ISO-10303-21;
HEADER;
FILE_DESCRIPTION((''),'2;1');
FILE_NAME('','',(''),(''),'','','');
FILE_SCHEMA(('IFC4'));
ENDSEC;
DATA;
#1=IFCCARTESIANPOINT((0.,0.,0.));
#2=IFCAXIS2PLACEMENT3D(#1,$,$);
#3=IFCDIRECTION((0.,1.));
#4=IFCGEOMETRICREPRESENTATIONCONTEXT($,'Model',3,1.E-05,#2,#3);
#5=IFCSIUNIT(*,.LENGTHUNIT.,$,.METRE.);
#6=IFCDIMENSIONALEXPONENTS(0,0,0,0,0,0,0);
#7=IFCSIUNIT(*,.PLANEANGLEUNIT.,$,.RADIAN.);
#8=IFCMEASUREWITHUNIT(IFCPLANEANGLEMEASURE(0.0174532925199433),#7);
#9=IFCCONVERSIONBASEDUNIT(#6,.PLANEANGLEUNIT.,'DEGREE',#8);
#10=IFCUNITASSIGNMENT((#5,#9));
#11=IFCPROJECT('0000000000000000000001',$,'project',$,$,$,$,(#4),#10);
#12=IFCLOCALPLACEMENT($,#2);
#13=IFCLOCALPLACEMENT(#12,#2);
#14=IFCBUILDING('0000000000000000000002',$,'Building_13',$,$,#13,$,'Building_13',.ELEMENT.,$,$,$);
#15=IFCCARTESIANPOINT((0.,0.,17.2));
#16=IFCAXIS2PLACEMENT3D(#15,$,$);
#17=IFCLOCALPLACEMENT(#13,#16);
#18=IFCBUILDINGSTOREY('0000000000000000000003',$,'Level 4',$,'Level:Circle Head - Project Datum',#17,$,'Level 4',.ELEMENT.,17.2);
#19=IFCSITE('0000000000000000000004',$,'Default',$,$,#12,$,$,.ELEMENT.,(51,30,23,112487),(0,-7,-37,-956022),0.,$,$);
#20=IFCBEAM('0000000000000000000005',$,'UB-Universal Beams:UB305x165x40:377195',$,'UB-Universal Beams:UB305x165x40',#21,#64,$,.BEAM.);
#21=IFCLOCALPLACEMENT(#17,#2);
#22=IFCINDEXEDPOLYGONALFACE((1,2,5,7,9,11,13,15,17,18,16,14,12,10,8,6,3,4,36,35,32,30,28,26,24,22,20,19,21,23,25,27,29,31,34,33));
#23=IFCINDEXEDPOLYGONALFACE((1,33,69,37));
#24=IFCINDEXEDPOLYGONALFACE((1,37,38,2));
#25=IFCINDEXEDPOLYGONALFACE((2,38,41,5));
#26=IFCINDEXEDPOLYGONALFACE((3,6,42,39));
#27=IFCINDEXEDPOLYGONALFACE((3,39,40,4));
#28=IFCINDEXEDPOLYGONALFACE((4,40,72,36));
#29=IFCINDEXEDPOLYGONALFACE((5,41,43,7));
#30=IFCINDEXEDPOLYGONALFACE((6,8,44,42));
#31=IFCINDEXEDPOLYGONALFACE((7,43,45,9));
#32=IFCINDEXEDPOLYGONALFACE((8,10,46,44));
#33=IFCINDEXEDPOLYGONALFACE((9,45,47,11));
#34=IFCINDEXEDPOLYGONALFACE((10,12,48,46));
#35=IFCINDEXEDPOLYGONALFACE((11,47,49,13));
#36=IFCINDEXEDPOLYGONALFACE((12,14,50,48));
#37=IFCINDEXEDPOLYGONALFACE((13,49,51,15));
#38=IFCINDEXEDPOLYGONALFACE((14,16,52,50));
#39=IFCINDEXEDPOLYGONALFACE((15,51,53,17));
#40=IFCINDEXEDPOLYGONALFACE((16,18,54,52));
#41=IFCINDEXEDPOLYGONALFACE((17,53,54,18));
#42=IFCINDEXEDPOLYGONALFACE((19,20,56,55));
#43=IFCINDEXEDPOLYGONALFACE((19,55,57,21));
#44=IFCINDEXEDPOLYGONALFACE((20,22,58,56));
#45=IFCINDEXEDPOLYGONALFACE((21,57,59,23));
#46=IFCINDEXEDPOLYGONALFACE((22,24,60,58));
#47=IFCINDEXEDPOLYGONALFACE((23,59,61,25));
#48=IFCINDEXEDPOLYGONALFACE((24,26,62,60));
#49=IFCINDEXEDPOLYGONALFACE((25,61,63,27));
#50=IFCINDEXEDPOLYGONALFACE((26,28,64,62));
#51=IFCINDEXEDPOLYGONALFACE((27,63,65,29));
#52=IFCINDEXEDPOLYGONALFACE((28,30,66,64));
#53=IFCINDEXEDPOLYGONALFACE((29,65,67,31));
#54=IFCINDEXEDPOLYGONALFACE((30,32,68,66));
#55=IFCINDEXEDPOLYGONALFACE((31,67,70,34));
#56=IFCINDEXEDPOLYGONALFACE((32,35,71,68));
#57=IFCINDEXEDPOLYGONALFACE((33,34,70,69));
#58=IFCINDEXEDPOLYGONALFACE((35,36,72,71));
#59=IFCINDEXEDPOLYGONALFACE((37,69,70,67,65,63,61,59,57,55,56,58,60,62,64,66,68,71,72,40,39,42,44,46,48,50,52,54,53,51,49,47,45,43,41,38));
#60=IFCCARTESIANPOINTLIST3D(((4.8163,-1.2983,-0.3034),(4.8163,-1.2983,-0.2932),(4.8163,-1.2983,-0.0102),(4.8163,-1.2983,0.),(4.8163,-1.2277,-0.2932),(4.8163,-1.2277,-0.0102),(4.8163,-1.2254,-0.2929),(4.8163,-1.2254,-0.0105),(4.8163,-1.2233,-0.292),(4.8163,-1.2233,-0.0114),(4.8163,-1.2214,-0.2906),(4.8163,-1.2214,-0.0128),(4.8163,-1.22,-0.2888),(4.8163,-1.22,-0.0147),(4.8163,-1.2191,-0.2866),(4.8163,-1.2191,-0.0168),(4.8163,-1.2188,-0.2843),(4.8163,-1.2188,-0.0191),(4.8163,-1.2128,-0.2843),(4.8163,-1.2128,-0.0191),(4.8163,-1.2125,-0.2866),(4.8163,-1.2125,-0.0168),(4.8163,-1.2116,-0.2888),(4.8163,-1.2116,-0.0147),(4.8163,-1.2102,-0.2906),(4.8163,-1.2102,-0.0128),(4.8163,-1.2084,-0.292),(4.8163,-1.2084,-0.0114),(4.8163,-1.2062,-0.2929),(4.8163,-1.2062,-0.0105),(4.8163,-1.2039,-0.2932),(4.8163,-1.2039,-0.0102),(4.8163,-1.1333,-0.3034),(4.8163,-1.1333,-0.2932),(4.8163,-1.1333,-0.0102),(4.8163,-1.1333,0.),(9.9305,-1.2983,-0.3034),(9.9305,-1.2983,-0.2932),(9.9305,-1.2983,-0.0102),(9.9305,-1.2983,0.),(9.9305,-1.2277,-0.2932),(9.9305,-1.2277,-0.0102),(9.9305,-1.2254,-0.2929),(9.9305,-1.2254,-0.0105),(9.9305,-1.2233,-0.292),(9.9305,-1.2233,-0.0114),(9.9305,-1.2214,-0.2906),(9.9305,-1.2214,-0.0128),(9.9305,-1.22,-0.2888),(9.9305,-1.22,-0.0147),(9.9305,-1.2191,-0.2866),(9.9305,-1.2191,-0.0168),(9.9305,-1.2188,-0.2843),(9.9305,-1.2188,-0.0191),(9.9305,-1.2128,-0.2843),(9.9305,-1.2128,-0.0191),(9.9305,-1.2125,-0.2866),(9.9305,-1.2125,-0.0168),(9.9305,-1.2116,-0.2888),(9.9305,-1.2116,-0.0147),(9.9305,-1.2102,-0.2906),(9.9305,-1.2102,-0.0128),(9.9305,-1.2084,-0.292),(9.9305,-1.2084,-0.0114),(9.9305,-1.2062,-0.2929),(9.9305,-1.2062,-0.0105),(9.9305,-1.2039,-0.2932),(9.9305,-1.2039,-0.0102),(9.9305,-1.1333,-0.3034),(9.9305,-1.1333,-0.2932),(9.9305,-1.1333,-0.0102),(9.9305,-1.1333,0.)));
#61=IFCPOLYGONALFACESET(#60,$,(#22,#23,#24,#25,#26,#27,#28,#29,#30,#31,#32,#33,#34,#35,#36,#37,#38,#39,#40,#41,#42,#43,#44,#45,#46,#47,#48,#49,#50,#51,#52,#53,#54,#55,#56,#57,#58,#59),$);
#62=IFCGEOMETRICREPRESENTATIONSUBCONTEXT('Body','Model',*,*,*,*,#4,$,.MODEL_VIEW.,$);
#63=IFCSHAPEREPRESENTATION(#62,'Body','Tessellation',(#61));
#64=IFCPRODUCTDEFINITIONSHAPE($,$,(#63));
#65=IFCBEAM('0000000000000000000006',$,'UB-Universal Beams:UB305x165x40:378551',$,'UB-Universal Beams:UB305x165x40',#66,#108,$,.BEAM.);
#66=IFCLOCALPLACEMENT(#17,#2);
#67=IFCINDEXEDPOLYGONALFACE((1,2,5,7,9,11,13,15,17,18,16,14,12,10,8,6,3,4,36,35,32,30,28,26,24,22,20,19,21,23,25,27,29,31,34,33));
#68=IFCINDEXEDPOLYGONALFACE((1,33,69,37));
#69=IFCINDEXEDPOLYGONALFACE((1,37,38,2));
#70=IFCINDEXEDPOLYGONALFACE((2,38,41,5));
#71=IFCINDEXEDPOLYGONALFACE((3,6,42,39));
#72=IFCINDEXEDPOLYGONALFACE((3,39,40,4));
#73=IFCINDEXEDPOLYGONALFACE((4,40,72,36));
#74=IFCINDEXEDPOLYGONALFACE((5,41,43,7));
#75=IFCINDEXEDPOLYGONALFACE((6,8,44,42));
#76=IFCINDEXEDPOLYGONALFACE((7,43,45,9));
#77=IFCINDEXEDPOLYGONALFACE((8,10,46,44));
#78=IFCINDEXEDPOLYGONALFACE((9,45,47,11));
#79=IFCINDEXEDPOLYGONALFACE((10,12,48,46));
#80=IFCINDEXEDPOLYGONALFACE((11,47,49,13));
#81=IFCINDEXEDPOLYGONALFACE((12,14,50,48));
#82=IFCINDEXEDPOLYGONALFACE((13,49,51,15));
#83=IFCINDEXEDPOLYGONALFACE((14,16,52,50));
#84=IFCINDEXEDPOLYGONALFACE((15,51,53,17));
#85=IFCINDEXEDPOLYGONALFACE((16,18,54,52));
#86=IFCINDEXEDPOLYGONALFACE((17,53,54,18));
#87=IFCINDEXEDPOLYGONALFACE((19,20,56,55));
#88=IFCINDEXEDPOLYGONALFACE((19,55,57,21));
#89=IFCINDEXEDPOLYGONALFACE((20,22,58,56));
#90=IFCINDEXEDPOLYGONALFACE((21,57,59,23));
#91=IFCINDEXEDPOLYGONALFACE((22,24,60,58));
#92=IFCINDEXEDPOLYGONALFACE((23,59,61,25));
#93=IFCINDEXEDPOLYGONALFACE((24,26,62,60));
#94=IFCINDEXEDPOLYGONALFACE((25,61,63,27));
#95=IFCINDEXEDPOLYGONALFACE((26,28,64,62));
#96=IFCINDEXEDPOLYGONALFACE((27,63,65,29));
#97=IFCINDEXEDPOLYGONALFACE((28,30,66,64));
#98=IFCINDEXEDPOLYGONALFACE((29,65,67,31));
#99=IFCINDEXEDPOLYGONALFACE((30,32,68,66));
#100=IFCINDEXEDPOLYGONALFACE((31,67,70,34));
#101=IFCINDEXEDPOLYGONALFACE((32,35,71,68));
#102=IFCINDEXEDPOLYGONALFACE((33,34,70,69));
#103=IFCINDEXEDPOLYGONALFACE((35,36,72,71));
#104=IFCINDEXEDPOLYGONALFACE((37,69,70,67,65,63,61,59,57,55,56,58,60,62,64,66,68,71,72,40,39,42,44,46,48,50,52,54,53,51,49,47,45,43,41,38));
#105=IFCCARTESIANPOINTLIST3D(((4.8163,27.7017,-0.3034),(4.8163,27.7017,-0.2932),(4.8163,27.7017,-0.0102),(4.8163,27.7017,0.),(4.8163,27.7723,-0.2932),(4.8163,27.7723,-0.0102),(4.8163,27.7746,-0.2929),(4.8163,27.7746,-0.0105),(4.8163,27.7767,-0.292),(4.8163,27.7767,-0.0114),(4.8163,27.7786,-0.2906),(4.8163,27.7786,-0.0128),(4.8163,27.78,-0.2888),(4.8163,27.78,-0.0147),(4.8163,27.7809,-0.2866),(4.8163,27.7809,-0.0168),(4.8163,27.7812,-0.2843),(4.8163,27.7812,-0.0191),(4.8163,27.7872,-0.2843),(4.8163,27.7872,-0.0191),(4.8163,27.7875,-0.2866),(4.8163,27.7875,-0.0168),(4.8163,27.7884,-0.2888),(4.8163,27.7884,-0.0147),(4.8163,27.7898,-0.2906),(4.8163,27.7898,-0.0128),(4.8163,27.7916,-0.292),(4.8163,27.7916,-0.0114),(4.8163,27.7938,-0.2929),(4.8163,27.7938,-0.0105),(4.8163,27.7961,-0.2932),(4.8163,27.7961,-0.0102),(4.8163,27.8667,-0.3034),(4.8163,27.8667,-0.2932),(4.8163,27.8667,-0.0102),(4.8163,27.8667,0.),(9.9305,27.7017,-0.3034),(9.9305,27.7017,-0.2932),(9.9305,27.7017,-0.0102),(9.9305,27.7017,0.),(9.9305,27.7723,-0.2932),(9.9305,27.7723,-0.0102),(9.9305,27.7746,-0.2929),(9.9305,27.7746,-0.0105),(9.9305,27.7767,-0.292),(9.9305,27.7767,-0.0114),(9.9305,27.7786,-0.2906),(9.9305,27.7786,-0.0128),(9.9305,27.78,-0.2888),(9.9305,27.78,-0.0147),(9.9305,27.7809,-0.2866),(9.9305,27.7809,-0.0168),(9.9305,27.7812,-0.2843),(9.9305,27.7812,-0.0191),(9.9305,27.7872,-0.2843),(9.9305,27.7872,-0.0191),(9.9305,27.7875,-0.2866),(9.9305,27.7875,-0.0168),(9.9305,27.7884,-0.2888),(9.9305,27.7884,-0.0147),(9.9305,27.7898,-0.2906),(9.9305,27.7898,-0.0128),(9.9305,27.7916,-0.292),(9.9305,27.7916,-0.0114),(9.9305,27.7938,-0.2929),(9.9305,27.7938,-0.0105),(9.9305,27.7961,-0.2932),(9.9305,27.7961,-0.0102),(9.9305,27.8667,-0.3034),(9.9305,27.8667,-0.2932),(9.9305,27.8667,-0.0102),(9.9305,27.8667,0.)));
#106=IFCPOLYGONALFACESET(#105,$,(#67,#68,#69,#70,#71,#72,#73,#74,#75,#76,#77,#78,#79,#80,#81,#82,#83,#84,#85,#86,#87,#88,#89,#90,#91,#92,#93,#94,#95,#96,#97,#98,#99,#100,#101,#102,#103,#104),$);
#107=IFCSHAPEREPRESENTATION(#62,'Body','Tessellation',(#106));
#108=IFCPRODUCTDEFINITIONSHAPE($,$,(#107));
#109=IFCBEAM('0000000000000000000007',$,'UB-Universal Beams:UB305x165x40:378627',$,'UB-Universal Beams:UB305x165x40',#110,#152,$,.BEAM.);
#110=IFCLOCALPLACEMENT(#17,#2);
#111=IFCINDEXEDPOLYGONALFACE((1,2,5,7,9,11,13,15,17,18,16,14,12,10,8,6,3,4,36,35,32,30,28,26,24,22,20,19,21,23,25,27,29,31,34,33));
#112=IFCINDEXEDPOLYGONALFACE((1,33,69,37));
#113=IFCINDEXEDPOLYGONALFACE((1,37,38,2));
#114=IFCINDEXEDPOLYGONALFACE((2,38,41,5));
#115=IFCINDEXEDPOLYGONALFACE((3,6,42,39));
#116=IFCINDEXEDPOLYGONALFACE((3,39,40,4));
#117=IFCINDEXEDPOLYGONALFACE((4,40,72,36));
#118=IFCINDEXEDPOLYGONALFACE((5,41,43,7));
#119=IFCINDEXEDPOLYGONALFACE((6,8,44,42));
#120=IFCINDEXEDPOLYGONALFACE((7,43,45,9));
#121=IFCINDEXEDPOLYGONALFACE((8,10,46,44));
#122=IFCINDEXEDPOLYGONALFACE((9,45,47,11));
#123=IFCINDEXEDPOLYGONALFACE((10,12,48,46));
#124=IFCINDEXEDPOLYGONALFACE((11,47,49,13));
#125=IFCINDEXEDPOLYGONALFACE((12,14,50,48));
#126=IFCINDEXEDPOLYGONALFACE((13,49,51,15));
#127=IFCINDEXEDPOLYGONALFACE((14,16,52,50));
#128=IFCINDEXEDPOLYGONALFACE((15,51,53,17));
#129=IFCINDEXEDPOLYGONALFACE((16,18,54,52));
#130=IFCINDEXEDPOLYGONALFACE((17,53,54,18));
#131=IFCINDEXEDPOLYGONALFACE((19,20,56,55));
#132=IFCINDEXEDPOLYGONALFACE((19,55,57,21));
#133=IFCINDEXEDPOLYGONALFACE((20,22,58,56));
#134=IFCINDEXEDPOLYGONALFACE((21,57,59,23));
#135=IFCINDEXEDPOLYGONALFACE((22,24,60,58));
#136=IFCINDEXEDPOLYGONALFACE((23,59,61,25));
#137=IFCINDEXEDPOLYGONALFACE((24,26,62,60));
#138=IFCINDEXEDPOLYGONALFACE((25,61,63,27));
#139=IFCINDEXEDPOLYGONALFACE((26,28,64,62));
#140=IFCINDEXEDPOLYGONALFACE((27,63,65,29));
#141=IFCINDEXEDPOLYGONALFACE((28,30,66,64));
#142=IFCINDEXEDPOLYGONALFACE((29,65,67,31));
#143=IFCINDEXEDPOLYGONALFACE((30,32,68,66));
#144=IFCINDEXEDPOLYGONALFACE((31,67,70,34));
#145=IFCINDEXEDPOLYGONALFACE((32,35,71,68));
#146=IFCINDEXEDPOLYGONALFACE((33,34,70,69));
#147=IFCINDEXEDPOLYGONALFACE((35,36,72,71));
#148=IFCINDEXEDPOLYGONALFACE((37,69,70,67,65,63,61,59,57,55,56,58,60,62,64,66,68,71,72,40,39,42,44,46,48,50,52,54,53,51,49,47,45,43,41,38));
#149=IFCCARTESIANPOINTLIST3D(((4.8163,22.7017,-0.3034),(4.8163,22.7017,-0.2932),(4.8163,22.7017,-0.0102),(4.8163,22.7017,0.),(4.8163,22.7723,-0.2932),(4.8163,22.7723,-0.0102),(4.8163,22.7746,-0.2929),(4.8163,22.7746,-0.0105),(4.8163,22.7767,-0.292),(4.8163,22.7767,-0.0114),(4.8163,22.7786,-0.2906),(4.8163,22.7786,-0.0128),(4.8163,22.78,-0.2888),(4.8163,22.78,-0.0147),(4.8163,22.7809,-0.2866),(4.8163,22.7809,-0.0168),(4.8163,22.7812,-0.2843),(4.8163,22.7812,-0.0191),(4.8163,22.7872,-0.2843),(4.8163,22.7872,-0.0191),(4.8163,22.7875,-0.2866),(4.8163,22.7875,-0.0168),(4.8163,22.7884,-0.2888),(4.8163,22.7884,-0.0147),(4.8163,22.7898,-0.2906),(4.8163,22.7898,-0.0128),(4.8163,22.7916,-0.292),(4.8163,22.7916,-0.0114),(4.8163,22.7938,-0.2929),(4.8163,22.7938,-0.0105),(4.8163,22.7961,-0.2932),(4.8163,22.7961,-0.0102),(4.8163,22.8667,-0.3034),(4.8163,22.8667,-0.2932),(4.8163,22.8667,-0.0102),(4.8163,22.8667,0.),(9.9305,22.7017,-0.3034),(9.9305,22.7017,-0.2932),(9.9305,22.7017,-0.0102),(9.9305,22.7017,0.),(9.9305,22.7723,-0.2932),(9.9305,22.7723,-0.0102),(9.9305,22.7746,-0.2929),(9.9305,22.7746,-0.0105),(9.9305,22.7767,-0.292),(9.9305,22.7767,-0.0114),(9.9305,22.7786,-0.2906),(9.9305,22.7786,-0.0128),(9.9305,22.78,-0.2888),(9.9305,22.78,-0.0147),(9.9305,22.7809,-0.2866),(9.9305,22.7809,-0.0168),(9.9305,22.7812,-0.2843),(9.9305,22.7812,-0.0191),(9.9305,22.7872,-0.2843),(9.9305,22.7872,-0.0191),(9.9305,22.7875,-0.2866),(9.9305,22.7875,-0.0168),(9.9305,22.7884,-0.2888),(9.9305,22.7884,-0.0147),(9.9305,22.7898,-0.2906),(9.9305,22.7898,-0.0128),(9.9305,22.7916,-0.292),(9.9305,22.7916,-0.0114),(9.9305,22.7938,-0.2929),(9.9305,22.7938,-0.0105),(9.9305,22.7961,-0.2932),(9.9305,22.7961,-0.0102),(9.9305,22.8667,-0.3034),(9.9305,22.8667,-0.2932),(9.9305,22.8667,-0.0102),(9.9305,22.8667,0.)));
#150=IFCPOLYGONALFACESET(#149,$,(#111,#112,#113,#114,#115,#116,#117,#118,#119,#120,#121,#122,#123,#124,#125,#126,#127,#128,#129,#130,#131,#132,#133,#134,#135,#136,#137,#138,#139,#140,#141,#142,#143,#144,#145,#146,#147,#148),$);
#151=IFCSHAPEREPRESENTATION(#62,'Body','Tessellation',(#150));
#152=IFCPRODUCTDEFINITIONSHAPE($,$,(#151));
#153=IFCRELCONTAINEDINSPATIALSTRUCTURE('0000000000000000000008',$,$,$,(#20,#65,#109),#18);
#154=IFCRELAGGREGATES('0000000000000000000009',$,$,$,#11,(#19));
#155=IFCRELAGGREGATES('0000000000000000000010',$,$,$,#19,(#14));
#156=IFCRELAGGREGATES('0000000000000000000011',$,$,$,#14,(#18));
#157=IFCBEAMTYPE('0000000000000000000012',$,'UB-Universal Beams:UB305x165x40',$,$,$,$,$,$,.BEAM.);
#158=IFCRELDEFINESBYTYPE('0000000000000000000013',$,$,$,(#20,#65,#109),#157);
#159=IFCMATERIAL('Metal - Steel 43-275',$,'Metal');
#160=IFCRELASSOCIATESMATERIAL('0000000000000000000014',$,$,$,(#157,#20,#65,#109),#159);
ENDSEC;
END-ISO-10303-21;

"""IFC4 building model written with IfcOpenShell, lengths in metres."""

from ifc_helpers import new_model, entity, si_unit, converted_unit, direction, frame, origin, place, context, subcontext, project, spatial, line, arc, indexed_curve, outline, extrude, source, transform, mapped, material, type_object, type_shapes, element, save


model = new_model("IFC4")

# Units and contexts
model_context = context("Model", 3, precision=1e-05, world=origin(), true_north=direction((0.0, 1.0)))
body_context = subcontext(model_context, "Body", "Model", "MODEL_VIEW")
ifc_project = project(units=[si_unit("LENGTHUNIT", "METRE"), converted_unit("PLANEANGLEUNIT", "DEGREE", entity("IfcPlaneAngleMeasure", 0.0174532925199433), si_unit("PLANEANGLEUNIT", "RADIAN"), dimensions=[0, 0, 0, 0, 0, 0, 0])], contexts=[model_context])

# Site, building, storey
site_placement = place(None, origin())
site = spatial("IfcSite", under=ifc_project, at=site_placement, Name="Default", CompositionType="ELEMENT", RefLatitude=(51, 30, 23, 112487), RefLongitude=(0, -7, -37, -956022), RefElevation=0.0)
building_placement = place(site_placement, origin())
building = spatial("IfcBuilding", under=site, at=building_placement, Name="Building_13", LongName="Building_13", CompositionType="ELEMENT")
storey_placement = place(building_placement, frame((0.0, 0.0, 17.2)))
storey = spatial("IfcBuildingStorey", under=building, at=storey_placement, Name="Level 4", ObjectType="Level:Circle Head - Project Datum", LongName="Level 4", CompositionType="ELEMENT", Elevation=17.2)

# Beams
ifc_material_1 = material(Name="Metal - Steel 43-275", Category="Metal")
beam_type_1 = type_object("IfcBeamType", Name="UB-Universal Beams:UB305x165x40", PredefinedType="BEAM", material=ifc_material_1)
shared_shape_1 = source(origin(), body_context, "Body", "SweptSolid", [
    extrude(outline(indexed_curve([(-0.0825, -0.1415), (-0.0825, -0.1517), (0.0825, -0.1517), (0.0825, -0.1415), (0.0119, -0.1415), (0.0056, -0.1389), (0.003, -0.1326), (0.003, 0.1326), (0.0056, 0.1389), (0.0119, 0.1415), (0.0825, 0.1415), (0.0825, 0.1517), (-0.0825, 0.1517), (-0.0825, 0.1415), (-0.0119, 0.1415), (-0.0056, 0.1389), (-0.003, 0.1326), (-0.003, -0.1326), (-0.0056, -0.1389), (-0.0119, -0.1415)], segments=[line(1, 2, 3, 4, 5), arc(5, 6, 7), line(7, 8), arc(8, 9, 10), line(10, 11, 12, 13, 14, 15), arc(15, 16, 17), line(17, 18), arc(18, 19, 20), line(20, 1)], self_intersect=False)), frame((-2.5571, 0.0, 0.0), z_axis=(-1.0, 0.0, 0.0), x_axis=(0.0, -1.0, 0.0)), (0.0, 0.0, -1.0), 5.1142),
])
type_shapes(beam_type_1, [shared_shape_1])
beam_1_placement = place(storey_placement, frame((7.3734, -1.2158, -0.1517), z_axis=(0.0, 0.0, 1.0), x_axis=(-1.0, 0.0, 0.0)))
element("IfcBeam", 1, at=beam_1_placement, inside=storey, type_object=beam_type_1, material=ifc_material_1, Name="UB-Universal Beams:UB305x165x40:377195", ObjectType="UB-Universal Beams:UB305x165x40", PredefinedType="BEAM", context=body_context, shape_type="MappedRepresentation", body=[
    mapped(shared_shape_1, transform((0.0, 0.0, 0.0), scale=1.0)),
])
for number, where, name in (
    (2, (7.3734, 27.7842, -0.1517), "UB-Universal Beams:UB305x165x40:378551"),
    (3, (7.3734, 22.7842, -0.1517), "UB-Universal Beams:UB305x165x40:378627"),
):
    element("IfcBeam", number, at=place(storey_placement, frame(where)), inside=storey, type_object=beam_type_1, material=ifc_material_1, Name=name, ObjectType="UB-Universal Beams:UB305x165x40", PredefinedType="BEAM", context=body_context, shape_type="MappedRepresentation", body=[
        mapped(shared_shape_1, transform((0.0, 0.0, 0.0), scale=1.0)),
    ])

save(model, "model.ifc")
